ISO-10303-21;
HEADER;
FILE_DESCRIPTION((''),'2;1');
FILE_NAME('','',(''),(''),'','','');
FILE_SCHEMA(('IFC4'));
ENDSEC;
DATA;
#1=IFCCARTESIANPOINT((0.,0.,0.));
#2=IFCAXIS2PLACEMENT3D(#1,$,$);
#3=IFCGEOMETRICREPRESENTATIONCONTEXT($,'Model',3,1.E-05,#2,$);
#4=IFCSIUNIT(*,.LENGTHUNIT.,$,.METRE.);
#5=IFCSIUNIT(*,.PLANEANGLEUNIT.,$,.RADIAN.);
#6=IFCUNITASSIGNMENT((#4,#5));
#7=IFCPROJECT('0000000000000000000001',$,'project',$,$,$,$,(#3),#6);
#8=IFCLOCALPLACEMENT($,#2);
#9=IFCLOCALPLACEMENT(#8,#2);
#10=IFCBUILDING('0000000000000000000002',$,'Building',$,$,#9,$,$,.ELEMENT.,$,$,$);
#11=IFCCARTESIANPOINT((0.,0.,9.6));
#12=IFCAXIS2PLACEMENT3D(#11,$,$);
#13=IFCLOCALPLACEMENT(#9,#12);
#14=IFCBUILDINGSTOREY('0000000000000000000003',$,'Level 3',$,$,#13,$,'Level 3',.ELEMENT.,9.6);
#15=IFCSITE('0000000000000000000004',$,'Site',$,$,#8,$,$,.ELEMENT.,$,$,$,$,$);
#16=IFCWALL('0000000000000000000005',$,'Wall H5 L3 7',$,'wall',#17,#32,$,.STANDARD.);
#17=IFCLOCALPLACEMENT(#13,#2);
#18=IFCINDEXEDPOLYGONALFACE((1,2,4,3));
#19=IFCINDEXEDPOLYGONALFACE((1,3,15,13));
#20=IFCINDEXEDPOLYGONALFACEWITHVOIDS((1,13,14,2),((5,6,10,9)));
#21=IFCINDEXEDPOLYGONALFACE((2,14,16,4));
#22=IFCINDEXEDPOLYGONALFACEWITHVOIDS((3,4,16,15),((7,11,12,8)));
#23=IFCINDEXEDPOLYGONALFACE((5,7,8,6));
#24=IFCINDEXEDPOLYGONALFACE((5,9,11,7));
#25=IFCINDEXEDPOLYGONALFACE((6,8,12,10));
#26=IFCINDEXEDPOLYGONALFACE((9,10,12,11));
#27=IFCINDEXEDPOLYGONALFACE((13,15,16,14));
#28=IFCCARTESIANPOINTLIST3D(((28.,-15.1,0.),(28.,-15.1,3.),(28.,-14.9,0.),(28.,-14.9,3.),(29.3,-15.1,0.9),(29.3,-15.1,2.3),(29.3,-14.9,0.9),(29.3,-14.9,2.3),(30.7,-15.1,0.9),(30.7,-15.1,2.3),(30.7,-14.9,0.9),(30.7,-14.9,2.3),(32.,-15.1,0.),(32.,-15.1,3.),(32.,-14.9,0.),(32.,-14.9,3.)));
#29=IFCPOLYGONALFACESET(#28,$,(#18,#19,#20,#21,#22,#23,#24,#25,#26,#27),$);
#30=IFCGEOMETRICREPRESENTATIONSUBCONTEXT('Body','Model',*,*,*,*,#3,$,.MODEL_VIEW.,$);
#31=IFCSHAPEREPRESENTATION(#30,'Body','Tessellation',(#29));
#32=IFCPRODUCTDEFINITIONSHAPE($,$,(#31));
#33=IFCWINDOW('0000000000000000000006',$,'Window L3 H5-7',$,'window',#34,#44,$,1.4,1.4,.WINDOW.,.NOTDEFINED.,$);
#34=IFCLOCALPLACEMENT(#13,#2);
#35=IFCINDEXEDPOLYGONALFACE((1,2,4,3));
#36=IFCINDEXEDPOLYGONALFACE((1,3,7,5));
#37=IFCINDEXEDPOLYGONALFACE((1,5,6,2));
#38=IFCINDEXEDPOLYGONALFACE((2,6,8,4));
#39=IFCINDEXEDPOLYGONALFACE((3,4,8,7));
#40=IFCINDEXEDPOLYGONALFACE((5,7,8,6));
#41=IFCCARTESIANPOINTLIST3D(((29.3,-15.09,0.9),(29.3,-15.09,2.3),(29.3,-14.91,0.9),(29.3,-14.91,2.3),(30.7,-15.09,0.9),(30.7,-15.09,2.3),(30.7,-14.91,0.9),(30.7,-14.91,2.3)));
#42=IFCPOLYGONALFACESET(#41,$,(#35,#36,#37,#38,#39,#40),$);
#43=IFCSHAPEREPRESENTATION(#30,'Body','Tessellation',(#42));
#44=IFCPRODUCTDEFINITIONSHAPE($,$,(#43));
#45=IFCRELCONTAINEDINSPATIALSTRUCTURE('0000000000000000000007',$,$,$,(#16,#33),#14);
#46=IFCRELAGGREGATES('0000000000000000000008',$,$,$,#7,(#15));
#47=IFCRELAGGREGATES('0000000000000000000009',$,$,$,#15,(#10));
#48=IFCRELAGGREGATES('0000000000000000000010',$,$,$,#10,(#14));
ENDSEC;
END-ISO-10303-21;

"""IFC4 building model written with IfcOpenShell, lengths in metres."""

from ifc_helpers import new_model, si_unit, frame, frame_2d, origin, origin_2d, place, context, subcontext, project, spatial, rectangle, extrude, element, fill, save


model = new_model("IFC4")

# Units and contexts
model_context = context("Model", 3, precision=1e-05, world=origin())
body_context = subcontext(model_context, "Body", "Model", "MODEL_VIEW")
ifc_project = project(units=[si_unit("LENGTHUNIT", "METRE"), si_unit("PLANEANGLEUNIT", "RADIAN")], contexts=[model_context])

# Site, building, storey
site_placement = place(None, origin())
site = spatial("IfcSite", under=ifc_project, at=site_placement, Name="Site", CompositionType="ELEMENT")
building_placement = place(site_placement, origin())
building = spatial("IfcBuilding", under=site, at=building_placement, Name="Building", CompositionType="ELEMENT")
storey_placement = place(building_placement, frame((0.0, 0.0, 9.6)))
storey = spatial("IfcBuildingStorey", under=building, at=storey_placement, Name="Level 3", LongName="Level 3", CompositionType="ELEMENT", Elevation=9.6)

# Wall, opening, window
wall_1_placement = place(storey_placement, frame((28.0, -15.0, 0.0), z_axis=(0.0, 0.0, 1.0), x_axis=(1.0, 0.0, 0.0)))
wall_1 = element("IfcWall", 1, at=wall_1_placement, inside=storey, Name="Wall H5 L3 7", ObjectType="wall", PredefinedType="STANDARD", context=body_context, shape_type="SweptSolid", body=[
    extrude(rectangle(XDim=4.0, YDim=0.2, at=frame_2d((2.0, 0.0))), origin(), (0.0, 0.0, 1.0), 3.0),
])
opening_1_placement = place(storey_placement, frame((30.0, -15.0, 0.9), z_axis=(0.0, 0.0, 1.0), x_axis=(1.0, 0.0, 0.0)))
opening_1 = element("IfcOpeningElement", 2, at=opening_1_placement, cuts=wall_1, ObjectType="Opening", PredefinedType="OPENING", context=body_context, shape_type="SweptSolid", body=[
    extrude(rectangle(XDim=1.4, YDim=0.22, at=origin_2d()), origin(), (0.0, 0.0, 1.0), 1.4),
])
window_1_placement = place(storey_placement, frame((30.0, -15.0, 0.9), z_axis=(0.0, 0.0, 1.0), x_axis=(1.0, 0.0, 0.0)))
window_1 = element("IfcWindow", 3, at=window_1_placement, inside=storey, Name="Window L3 H5-7", ObjectType="window", OverallHeight=1.4, OverallWidth=1.4, PartitioningType="NOTDEFINED", PredefinedType="WINDOW", context=body_context, shape_type="SweptSolid", body=[
    extrude(rectangle(XDim=1.4, YDim=0.18, at=origin_2d()), origin(), (0.0, 0.0, 1.0), 1.4),
])
fill(opening_1, window_1)

save(model, "model.ifc")
